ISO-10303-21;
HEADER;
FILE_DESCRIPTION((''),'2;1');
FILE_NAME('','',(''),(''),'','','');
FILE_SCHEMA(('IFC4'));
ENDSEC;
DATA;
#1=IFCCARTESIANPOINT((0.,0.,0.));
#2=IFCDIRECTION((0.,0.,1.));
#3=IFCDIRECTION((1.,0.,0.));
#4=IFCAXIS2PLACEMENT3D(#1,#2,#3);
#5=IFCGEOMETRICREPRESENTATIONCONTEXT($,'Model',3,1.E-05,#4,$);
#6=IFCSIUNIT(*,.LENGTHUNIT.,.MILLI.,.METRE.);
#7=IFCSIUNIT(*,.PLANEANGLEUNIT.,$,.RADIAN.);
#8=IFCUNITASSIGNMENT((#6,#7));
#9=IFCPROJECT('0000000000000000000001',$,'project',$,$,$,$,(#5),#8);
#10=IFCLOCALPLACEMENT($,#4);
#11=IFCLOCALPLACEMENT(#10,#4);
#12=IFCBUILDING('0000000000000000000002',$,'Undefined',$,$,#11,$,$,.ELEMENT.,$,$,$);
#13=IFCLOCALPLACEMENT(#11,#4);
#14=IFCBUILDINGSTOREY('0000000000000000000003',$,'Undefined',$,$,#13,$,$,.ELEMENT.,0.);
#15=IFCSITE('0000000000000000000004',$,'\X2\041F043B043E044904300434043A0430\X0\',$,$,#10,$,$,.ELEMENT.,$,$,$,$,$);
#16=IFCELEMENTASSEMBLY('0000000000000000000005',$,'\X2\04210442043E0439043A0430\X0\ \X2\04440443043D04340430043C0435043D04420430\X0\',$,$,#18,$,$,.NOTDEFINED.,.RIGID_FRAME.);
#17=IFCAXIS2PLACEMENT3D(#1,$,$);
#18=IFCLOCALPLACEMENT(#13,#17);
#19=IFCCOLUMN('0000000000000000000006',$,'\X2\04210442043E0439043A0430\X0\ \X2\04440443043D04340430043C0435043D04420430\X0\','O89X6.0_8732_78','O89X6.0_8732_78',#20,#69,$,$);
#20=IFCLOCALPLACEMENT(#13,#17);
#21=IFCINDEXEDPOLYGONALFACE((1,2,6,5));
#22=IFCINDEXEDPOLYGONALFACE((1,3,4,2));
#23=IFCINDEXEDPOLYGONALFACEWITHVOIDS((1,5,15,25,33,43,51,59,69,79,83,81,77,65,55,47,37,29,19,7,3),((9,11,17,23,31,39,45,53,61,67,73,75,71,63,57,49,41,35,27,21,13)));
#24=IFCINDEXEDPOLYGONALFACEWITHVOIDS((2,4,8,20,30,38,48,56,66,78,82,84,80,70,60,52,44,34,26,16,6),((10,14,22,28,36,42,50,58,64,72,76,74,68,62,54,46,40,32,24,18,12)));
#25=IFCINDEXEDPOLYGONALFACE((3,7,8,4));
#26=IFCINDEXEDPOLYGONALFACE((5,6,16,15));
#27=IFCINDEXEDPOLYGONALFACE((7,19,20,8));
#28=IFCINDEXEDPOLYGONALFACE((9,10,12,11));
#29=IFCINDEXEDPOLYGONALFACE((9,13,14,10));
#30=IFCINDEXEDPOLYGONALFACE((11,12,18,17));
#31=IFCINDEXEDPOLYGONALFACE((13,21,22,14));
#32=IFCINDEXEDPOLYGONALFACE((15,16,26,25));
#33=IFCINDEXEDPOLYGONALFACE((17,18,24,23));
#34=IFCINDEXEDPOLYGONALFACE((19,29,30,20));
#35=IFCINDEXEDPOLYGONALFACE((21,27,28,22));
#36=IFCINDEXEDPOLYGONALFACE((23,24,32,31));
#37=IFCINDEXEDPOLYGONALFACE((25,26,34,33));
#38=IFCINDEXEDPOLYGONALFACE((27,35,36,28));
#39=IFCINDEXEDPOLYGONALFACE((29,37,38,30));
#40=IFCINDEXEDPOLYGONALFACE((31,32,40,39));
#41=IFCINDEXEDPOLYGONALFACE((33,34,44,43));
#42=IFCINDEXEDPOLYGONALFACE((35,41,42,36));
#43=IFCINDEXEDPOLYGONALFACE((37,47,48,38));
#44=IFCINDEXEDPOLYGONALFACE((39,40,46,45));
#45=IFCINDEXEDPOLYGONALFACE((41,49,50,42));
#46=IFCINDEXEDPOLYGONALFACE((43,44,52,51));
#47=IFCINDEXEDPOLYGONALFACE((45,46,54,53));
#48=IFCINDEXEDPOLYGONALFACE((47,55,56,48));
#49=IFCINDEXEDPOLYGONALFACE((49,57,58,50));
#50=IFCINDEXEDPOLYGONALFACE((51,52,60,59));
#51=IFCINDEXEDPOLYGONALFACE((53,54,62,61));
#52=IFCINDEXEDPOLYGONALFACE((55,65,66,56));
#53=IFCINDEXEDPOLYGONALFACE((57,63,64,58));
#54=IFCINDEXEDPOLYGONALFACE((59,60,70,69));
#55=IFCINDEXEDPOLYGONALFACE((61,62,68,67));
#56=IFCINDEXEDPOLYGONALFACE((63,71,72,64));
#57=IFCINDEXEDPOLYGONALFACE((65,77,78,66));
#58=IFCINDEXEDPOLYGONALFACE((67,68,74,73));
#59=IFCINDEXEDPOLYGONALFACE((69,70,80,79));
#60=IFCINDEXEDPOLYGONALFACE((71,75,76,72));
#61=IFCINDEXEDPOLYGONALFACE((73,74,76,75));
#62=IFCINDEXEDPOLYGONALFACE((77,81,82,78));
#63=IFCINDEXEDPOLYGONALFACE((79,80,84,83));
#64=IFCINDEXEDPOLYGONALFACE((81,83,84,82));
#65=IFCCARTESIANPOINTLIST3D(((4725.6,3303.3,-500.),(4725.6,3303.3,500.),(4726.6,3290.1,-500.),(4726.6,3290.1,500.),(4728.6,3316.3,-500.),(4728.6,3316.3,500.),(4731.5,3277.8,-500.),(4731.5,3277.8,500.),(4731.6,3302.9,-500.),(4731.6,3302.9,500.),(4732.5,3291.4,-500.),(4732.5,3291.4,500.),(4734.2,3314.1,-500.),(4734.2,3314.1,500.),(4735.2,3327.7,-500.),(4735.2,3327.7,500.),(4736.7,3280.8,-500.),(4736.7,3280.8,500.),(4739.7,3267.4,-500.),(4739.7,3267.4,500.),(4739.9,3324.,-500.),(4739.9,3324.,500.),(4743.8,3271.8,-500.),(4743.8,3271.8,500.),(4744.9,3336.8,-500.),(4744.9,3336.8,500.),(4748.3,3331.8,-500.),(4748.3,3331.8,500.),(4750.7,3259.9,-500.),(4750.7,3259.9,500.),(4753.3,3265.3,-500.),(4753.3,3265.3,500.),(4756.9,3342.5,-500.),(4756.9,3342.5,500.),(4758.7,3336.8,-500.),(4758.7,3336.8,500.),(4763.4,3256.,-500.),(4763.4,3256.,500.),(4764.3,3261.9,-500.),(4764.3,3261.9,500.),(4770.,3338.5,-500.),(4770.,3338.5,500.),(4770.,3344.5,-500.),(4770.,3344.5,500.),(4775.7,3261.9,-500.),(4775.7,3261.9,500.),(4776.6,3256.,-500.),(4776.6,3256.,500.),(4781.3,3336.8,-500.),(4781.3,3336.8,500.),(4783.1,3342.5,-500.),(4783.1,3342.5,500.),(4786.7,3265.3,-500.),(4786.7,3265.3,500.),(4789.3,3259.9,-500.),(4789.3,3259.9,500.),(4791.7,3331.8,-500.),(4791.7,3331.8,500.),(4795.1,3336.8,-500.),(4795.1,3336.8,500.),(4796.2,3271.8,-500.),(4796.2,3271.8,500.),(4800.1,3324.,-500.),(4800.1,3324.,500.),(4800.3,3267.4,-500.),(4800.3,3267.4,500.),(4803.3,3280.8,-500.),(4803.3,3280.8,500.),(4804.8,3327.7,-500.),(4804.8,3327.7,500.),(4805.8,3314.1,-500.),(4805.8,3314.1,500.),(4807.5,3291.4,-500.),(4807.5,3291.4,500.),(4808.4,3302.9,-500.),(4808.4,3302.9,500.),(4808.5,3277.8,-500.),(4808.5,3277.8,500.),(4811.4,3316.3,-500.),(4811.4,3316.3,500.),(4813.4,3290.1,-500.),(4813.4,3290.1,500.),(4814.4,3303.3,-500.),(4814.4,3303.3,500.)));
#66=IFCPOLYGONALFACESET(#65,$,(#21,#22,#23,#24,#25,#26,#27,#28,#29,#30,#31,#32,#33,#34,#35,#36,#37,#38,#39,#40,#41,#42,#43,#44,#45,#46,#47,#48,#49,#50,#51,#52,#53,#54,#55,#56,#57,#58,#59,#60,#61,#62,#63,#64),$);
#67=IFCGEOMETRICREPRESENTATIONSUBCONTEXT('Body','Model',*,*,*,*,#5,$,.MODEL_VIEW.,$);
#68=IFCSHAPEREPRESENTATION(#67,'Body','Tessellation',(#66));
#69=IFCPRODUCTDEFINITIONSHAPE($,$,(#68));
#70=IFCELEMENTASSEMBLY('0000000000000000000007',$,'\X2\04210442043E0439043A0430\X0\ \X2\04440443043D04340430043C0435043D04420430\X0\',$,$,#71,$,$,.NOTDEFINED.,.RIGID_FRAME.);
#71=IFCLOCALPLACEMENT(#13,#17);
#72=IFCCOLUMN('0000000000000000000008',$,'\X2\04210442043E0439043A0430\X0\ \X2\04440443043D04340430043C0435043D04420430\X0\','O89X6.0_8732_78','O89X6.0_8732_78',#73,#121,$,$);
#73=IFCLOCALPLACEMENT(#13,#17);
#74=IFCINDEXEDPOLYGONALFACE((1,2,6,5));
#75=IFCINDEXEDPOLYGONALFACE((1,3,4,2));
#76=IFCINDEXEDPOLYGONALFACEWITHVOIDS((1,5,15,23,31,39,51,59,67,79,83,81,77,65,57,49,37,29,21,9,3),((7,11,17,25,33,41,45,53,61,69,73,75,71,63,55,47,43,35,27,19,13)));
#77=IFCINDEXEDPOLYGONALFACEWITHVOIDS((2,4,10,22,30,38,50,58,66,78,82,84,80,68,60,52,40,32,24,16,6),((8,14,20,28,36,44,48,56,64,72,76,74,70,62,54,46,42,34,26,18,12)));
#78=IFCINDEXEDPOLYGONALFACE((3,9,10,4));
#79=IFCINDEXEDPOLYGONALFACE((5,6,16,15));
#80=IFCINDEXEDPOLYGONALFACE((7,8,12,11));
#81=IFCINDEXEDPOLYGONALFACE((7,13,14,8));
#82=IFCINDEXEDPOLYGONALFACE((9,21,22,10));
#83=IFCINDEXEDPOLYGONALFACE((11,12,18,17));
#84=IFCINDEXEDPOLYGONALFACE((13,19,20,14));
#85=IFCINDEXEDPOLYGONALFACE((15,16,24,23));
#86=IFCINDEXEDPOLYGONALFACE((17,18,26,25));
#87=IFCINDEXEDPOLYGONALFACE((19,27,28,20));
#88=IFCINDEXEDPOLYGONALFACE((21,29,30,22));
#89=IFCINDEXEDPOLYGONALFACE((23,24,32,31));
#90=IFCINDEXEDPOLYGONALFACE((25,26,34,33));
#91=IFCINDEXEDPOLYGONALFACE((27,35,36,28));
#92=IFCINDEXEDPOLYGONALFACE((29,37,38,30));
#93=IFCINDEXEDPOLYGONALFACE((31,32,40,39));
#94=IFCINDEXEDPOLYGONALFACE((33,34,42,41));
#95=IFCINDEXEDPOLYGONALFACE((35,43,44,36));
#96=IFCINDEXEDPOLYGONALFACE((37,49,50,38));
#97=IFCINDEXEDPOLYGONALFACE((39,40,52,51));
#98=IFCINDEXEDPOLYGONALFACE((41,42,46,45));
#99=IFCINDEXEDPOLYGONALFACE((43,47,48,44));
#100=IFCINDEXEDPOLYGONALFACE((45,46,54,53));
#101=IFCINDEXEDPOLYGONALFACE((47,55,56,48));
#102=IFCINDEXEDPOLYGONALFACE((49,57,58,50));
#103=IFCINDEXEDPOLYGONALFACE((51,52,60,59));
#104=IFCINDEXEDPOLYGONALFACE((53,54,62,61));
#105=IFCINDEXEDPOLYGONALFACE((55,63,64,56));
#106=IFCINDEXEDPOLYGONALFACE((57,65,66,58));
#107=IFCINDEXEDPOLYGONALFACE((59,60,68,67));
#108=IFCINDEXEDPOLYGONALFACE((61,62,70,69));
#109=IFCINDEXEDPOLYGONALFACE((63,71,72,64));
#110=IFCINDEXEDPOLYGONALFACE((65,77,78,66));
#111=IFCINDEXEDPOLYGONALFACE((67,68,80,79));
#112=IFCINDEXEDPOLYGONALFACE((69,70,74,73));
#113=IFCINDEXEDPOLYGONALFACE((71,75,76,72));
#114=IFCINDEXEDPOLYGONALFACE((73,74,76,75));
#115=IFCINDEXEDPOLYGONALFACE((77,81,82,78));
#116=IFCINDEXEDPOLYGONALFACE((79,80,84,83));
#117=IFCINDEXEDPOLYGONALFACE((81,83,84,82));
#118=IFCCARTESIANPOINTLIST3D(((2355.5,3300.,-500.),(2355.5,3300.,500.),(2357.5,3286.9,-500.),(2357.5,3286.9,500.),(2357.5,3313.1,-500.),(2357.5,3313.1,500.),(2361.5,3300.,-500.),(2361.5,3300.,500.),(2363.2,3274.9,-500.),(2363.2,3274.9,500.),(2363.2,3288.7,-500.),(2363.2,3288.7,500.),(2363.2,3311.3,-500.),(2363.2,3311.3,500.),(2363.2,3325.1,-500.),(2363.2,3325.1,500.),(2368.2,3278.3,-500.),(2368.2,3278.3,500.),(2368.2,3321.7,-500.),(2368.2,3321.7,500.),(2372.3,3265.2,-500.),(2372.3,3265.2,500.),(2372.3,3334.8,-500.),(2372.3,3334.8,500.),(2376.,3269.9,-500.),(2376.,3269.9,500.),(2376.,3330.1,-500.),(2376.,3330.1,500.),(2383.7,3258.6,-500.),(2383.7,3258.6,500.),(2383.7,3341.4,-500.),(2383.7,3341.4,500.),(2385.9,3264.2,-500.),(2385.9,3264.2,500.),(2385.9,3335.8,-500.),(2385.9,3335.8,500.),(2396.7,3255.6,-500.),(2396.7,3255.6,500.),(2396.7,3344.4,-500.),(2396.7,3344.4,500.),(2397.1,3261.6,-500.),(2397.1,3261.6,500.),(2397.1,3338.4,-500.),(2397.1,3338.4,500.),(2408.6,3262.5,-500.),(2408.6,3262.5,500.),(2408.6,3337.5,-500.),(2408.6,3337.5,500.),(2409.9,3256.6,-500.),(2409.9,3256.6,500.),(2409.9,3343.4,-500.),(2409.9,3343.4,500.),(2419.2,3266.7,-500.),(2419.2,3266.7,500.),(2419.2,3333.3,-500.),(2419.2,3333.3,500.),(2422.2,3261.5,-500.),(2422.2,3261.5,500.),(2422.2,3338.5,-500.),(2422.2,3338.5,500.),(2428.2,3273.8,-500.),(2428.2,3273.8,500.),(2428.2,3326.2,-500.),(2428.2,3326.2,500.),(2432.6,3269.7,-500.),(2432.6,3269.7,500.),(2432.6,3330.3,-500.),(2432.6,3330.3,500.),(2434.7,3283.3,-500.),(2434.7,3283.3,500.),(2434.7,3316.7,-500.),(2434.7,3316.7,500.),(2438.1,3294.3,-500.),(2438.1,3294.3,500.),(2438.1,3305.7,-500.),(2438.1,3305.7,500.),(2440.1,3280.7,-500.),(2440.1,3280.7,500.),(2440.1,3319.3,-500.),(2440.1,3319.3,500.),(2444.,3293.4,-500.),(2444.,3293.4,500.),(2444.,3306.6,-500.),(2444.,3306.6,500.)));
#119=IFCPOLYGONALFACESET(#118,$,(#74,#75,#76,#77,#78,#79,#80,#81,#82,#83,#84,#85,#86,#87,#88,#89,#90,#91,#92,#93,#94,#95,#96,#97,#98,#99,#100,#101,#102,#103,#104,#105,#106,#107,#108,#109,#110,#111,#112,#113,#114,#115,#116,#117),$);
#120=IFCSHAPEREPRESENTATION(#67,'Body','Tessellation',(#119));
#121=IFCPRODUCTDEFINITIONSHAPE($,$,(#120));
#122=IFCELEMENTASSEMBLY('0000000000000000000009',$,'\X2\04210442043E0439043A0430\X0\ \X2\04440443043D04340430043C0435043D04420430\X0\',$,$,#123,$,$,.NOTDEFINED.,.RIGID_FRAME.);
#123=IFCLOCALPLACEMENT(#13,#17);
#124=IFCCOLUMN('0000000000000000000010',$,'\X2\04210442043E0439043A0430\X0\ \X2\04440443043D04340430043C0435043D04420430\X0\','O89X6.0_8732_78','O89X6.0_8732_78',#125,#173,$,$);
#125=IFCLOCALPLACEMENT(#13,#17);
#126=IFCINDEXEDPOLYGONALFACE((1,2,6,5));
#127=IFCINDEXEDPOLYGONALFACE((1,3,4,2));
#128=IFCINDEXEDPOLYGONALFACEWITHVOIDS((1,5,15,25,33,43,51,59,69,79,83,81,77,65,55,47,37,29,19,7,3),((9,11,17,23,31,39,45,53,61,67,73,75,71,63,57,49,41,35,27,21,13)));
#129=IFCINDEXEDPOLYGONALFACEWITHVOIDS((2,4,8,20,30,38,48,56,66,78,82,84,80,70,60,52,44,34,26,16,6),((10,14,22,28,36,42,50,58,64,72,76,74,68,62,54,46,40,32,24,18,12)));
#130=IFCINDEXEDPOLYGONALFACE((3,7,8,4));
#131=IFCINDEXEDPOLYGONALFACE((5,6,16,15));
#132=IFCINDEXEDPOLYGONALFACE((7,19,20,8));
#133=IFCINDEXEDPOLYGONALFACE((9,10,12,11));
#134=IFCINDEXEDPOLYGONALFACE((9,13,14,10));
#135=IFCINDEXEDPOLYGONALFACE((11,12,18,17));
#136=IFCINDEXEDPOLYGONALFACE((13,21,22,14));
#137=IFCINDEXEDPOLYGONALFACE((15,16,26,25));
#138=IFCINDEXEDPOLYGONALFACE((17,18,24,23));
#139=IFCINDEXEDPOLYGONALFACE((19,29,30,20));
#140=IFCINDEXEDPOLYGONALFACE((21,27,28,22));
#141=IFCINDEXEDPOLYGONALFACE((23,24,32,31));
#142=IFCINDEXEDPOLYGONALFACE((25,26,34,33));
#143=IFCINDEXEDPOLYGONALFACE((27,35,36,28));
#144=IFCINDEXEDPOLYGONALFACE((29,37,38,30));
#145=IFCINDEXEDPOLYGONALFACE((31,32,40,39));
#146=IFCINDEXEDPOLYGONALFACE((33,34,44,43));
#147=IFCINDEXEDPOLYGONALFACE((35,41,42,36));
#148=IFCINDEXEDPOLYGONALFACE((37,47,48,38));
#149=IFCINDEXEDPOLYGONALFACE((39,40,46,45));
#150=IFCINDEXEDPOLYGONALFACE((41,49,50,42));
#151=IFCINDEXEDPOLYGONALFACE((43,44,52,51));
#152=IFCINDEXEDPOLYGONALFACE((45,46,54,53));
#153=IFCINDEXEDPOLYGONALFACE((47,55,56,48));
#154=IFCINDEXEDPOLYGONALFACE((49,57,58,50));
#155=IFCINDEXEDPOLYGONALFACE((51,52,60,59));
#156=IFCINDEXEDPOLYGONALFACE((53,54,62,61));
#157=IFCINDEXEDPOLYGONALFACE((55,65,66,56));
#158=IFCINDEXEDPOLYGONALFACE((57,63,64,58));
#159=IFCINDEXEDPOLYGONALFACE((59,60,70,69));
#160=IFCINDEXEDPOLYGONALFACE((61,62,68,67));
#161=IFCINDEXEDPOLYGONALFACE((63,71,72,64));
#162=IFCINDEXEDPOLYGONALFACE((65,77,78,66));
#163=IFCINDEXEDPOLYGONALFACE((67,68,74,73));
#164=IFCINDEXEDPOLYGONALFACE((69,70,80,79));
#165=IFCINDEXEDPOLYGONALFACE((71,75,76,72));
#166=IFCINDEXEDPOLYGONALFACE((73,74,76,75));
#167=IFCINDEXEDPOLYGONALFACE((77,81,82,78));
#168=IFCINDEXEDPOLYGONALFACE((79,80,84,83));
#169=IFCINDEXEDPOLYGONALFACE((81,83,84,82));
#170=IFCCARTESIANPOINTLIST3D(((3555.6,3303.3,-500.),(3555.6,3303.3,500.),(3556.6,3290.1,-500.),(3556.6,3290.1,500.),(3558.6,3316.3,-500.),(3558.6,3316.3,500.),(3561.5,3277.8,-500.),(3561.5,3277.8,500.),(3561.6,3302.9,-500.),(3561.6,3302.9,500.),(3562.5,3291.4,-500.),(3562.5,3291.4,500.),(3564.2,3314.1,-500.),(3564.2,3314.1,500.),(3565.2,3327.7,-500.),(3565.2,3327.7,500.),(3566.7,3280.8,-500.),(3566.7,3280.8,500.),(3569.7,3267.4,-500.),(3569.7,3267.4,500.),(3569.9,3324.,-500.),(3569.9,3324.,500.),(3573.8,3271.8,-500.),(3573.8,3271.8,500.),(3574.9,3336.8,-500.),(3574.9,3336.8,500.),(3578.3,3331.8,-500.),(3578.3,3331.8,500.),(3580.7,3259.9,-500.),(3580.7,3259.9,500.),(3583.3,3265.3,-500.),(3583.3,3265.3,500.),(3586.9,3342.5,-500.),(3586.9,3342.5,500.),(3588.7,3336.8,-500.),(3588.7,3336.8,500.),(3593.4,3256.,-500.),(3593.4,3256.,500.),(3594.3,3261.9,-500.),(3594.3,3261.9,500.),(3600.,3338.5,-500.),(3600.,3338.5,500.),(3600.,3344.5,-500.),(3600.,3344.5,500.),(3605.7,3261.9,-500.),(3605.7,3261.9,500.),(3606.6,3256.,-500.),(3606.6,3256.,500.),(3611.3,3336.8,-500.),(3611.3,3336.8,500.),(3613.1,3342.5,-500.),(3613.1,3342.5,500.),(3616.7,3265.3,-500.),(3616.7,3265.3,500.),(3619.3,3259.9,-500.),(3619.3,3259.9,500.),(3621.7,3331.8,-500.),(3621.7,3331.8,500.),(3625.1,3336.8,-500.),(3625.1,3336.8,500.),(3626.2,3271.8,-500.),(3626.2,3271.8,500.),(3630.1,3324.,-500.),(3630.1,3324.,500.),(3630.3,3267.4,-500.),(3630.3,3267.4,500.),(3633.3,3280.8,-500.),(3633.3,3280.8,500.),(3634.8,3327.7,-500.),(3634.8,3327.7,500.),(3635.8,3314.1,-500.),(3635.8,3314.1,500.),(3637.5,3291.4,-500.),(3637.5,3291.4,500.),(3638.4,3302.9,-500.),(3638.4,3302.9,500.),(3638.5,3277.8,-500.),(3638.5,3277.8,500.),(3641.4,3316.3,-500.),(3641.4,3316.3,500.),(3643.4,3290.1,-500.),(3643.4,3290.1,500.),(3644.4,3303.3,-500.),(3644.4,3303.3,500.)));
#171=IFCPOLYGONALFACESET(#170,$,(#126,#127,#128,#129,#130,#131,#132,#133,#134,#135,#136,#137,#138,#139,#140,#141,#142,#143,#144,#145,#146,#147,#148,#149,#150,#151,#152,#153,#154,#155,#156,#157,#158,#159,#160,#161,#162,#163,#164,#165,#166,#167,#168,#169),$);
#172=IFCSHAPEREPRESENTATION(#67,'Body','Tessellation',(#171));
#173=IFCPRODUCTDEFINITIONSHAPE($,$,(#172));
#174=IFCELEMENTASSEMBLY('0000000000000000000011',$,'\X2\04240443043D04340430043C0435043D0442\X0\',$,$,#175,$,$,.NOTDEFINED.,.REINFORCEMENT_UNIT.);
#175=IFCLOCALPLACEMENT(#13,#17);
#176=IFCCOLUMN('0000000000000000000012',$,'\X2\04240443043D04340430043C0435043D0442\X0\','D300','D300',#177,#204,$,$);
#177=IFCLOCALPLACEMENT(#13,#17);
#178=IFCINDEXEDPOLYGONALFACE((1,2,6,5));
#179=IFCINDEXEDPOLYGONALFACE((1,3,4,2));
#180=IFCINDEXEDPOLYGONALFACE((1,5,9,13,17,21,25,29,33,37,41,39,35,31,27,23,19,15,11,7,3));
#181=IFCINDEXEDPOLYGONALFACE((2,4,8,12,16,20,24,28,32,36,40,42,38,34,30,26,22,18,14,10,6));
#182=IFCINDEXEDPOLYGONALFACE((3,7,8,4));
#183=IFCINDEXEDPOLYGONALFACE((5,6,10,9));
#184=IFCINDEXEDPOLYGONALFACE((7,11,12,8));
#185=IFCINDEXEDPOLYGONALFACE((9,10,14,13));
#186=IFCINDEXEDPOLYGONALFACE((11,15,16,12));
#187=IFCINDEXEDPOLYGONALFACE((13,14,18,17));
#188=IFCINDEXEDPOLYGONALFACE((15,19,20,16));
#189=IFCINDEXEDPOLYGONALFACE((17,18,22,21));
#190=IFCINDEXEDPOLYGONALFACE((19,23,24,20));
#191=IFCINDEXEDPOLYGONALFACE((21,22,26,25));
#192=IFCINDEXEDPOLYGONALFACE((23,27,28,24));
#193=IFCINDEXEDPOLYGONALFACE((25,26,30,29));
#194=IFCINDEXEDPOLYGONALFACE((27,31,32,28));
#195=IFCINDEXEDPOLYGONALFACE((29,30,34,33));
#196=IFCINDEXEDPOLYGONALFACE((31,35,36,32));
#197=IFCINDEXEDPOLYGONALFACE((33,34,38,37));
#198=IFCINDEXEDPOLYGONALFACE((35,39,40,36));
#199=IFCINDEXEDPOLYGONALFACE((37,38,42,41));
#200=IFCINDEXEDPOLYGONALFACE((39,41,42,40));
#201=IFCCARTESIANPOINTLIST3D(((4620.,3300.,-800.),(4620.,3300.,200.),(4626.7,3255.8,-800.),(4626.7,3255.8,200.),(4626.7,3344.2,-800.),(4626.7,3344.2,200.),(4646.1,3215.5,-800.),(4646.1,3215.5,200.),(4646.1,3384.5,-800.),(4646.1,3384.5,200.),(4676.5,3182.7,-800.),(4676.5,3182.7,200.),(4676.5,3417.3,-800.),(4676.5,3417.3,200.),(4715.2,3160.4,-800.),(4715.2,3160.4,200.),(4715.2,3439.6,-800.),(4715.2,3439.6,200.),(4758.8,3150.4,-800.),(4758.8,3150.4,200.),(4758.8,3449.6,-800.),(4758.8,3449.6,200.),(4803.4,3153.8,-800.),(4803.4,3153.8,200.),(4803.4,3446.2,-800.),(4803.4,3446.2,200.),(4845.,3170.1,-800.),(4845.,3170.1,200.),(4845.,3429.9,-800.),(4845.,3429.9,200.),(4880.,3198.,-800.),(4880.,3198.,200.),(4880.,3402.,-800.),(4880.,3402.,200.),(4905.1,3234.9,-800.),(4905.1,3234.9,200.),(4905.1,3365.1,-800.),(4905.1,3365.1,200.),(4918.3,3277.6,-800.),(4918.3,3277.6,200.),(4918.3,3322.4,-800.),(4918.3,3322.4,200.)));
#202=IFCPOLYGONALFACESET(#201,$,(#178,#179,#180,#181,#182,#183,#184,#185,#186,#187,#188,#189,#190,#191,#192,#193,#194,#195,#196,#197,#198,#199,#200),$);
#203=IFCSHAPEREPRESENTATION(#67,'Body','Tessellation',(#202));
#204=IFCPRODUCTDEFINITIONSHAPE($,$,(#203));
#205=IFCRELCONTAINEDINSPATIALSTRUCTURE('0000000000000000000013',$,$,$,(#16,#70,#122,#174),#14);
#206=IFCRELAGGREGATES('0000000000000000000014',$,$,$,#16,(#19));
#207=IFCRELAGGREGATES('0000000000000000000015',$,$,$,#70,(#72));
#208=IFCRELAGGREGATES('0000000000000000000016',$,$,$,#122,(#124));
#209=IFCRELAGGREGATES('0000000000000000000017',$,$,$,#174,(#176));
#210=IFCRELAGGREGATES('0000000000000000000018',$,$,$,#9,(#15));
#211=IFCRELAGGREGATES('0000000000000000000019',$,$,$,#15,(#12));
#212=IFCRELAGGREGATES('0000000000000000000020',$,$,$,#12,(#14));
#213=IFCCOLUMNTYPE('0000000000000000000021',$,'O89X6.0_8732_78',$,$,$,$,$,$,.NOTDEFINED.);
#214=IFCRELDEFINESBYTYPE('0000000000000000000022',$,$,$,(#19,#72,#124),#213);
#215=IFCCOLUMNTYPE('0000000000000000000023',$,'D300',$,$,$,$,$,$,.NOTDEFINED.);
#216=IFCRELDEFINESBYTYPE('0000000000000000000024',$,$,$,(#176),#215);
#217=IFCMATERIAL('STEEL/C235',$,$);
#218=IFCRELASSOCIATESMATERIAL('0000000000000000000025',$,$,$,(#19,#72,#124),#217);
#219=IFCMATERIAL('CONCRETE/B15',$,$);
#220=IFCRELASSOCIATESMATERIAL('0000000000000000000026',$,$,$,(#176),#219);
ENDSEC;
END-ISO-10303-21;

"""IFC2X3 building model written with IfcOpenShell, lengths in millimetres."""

from ifc_helpers import new_model, si_unit, frame, origin_with_axes, origin_2d_with_axis, place, context, subcontext, project, spatial, circle, hollow_circle, extrude, material, type_object, element, aggregate, save


model = new_model("IFC2X3")

# Units and contexts
model_context = context("Model", 3, precision=1e-05, world=origin_with_axes())
body_context = subcontext(model_context, "Body", "Model", "MODEL_VIEW")
ifc_project = project(units=[si_unit("LENGTHUNIT", "METRE", prefix="MILLI"), si_unit("PLANEANGLEUNIT", "RADIAN")], contexts=[model_context])

# Site, building, storey
site_placement = place(None, origin_with_axes())
site = spatial("IfcSite", under=ifc_project, at=site_placement, Name="Площадка", CompositionType="ELEMENT")
building_placement = place(site_placement, origin_with_axes())
building = spatial("IfcBuilding", under=site, at=building_placement, Name="Undefined", CompositionType="ELEMENT")
storey_placement = place(building_placement, origin_with_axes())
storey = spatial("IfcBuildingStorey", under=building, at=storey_placement, Name="Undefined", CompositionType="ELEMENT", Elevation=0.0)

# Element assemblies, columns
assembly_1_placement = place(storey_placement, origin_with_axes())
assembly_1 = element("IfcElementAssembly", 1, at=assembly_1_placement, inside=storey, Name="Стойка фундамента", AssemblyPlace="NOTDEFINED", PredefinedType="RIGID_FRAME")
ifc_material_1 = material(Name="STEEL/C235")
column_type_1 = type_object("IfcColumnType", Name="O89X6.0_8732_78", PredefinedType="NOTDEFINED")
column_1_placement = place(assembly_1_placement, frame((4770.0, 3300.0, -500.0), z_axis=(0.0, 0.0, 1.0), x_axis=(1.0, 0.0, 0.0)))
column_1 = element("IfcColumn", 2, at=column_1_placement, type_object=column_type_1, material=ifc_material_1, Name="Стойка фундамента", Description="O89X6.0_8732_78", ObjectType="O89X6.0_8732_78", context=body_context, shape_type="SweptSolid", body=[
    extrude(hollow_circle(Radius=44.5, WallThickness=6.0, at=origin_2d_with_axis()), frame((0.0, 0.0, 1000.0), z_axis=(0.0, 0.0, -1.0), x_axis=(0.0, 1.0, 0.0)), (0.0, 0.0, 1.0), 1000.0),
])
assembly_2_placement = place(storey_placement, origin_with_axes())
assembly_2 = element("IfcElementAssembly", 3, at=assembly_2_placement, inside=storey, Name="Стойка фундамента", AssemblyPlace="NOTDEFINED", PredefinedType="RIGID_FRAME")
column_2_placement = place(assembly_2_placement, frame((2400.0, 3300.0, -500.0), z_axis=(0.0, 0.0, 1.0), x_axis=(0.0, 1.0, 0.0)))
column_2 = element("IfcColumn", 4, at=column_2_placement, type_object=column_type_1, material=ifc_material_1, Name="Стойка фундамента", Description="O89X6.0_8732_78", ObjectType="O89X6.0_8732_78", context=body_context, shape_type="SweptSolid", body=[
    extrude(hollow_circle(Radius=44.5, WallThickness=6.0, at=origin_2d_with_axis()), frame((0.0, 0.0, 1000.0), z_axis=(0.0, 0.0, -1.0), x_axis=(0.0, 1.0, 0.0)), (0.0, 0.0, 1.0), 1000.0),
])
assembly_3_placement = place(storey_placement, origin_with_axes())
assembly_3 = element("IfcElementAssembly", 5, at=assembly_3_placement, inside=storey, Name="Стойка фундамента", AssemblyPlace="NOTDEFINED", PredefinedType="RIGID_FRAME")
column_3_placement = place(assembly_3_placement, frame((3600.0, 3300.0, -500.0), z_axis=(0.0, 0.0, 1.0), x_axis=(1.0, 0.0, 0.0)))
column_3 = element("IfcColumn", 6, at=column_3_placement, type_object=column_type_1, material=ifc_material_1, Name="Стойка фундамента", Description="O89X6.0_8732_78", ObjectType="O89X6.0_8732_78", context=body_context, shape_type="SweptSolid", body=[
    extrude(hollow_circle(Radius=44.5, WallThickness=6.0, at=origin_2d_with_axis()), frame((0.0, 0.0, 1000.0), z_axis=(0.0, 0.0, -1.0), x_axis=(0.0, 1.0, 0.0)), (0.0, 0.0, 1.0), 1000.0),
])
assembly_4_placement = place(storey_placement, origin_with_axes())
assembly_4 = element("IfcElementAssembly", 7, at=assembly_4_placement, inside=storey, Name="Фундамент", AssemblyPlace="NOTDEFINED", PredefinedType="REINFORCEMENT_UNIT")
ifc_material_2 = material(Name="CONCRETE/B15")
column_type_2 = type_object("IfcColumnType", Name="D300", PredefinedType="NOTDEFINED")
column_4_placement = place(assembly_4_placement, frame((4770.0, 3300.0, -800.0), z_axis=(0.0, 0.0, 1.0), x_axis=(0.0, 1.0, 0.0)))
column_4 = element("IfcColumn", 8, at=column_4_placement, type_object=column_type_2, material=ifc_material_2, Name="Фундамент", Description="D300", ObjectType="D300", context=body_context, shape_type="SweptSolid", body=[
    extrude(circle(Radius=150.0, at=origin_2d_with_axis()), frame((0.0, 0.0, 1000.0), z_axis=(0.0, 0.0, -1.0), x_axis=(0.0, 1.0, 0.0)), (0.0, 0.0, 1.0), 1000.0),
])

aggregate(assembly_1, [column_1])
aggregate(assembly_2, [column_2])
aggregate(assembly_3, [column_3])

aggregate(assembly_4, [column_4])

save(model, "model.ifc")
